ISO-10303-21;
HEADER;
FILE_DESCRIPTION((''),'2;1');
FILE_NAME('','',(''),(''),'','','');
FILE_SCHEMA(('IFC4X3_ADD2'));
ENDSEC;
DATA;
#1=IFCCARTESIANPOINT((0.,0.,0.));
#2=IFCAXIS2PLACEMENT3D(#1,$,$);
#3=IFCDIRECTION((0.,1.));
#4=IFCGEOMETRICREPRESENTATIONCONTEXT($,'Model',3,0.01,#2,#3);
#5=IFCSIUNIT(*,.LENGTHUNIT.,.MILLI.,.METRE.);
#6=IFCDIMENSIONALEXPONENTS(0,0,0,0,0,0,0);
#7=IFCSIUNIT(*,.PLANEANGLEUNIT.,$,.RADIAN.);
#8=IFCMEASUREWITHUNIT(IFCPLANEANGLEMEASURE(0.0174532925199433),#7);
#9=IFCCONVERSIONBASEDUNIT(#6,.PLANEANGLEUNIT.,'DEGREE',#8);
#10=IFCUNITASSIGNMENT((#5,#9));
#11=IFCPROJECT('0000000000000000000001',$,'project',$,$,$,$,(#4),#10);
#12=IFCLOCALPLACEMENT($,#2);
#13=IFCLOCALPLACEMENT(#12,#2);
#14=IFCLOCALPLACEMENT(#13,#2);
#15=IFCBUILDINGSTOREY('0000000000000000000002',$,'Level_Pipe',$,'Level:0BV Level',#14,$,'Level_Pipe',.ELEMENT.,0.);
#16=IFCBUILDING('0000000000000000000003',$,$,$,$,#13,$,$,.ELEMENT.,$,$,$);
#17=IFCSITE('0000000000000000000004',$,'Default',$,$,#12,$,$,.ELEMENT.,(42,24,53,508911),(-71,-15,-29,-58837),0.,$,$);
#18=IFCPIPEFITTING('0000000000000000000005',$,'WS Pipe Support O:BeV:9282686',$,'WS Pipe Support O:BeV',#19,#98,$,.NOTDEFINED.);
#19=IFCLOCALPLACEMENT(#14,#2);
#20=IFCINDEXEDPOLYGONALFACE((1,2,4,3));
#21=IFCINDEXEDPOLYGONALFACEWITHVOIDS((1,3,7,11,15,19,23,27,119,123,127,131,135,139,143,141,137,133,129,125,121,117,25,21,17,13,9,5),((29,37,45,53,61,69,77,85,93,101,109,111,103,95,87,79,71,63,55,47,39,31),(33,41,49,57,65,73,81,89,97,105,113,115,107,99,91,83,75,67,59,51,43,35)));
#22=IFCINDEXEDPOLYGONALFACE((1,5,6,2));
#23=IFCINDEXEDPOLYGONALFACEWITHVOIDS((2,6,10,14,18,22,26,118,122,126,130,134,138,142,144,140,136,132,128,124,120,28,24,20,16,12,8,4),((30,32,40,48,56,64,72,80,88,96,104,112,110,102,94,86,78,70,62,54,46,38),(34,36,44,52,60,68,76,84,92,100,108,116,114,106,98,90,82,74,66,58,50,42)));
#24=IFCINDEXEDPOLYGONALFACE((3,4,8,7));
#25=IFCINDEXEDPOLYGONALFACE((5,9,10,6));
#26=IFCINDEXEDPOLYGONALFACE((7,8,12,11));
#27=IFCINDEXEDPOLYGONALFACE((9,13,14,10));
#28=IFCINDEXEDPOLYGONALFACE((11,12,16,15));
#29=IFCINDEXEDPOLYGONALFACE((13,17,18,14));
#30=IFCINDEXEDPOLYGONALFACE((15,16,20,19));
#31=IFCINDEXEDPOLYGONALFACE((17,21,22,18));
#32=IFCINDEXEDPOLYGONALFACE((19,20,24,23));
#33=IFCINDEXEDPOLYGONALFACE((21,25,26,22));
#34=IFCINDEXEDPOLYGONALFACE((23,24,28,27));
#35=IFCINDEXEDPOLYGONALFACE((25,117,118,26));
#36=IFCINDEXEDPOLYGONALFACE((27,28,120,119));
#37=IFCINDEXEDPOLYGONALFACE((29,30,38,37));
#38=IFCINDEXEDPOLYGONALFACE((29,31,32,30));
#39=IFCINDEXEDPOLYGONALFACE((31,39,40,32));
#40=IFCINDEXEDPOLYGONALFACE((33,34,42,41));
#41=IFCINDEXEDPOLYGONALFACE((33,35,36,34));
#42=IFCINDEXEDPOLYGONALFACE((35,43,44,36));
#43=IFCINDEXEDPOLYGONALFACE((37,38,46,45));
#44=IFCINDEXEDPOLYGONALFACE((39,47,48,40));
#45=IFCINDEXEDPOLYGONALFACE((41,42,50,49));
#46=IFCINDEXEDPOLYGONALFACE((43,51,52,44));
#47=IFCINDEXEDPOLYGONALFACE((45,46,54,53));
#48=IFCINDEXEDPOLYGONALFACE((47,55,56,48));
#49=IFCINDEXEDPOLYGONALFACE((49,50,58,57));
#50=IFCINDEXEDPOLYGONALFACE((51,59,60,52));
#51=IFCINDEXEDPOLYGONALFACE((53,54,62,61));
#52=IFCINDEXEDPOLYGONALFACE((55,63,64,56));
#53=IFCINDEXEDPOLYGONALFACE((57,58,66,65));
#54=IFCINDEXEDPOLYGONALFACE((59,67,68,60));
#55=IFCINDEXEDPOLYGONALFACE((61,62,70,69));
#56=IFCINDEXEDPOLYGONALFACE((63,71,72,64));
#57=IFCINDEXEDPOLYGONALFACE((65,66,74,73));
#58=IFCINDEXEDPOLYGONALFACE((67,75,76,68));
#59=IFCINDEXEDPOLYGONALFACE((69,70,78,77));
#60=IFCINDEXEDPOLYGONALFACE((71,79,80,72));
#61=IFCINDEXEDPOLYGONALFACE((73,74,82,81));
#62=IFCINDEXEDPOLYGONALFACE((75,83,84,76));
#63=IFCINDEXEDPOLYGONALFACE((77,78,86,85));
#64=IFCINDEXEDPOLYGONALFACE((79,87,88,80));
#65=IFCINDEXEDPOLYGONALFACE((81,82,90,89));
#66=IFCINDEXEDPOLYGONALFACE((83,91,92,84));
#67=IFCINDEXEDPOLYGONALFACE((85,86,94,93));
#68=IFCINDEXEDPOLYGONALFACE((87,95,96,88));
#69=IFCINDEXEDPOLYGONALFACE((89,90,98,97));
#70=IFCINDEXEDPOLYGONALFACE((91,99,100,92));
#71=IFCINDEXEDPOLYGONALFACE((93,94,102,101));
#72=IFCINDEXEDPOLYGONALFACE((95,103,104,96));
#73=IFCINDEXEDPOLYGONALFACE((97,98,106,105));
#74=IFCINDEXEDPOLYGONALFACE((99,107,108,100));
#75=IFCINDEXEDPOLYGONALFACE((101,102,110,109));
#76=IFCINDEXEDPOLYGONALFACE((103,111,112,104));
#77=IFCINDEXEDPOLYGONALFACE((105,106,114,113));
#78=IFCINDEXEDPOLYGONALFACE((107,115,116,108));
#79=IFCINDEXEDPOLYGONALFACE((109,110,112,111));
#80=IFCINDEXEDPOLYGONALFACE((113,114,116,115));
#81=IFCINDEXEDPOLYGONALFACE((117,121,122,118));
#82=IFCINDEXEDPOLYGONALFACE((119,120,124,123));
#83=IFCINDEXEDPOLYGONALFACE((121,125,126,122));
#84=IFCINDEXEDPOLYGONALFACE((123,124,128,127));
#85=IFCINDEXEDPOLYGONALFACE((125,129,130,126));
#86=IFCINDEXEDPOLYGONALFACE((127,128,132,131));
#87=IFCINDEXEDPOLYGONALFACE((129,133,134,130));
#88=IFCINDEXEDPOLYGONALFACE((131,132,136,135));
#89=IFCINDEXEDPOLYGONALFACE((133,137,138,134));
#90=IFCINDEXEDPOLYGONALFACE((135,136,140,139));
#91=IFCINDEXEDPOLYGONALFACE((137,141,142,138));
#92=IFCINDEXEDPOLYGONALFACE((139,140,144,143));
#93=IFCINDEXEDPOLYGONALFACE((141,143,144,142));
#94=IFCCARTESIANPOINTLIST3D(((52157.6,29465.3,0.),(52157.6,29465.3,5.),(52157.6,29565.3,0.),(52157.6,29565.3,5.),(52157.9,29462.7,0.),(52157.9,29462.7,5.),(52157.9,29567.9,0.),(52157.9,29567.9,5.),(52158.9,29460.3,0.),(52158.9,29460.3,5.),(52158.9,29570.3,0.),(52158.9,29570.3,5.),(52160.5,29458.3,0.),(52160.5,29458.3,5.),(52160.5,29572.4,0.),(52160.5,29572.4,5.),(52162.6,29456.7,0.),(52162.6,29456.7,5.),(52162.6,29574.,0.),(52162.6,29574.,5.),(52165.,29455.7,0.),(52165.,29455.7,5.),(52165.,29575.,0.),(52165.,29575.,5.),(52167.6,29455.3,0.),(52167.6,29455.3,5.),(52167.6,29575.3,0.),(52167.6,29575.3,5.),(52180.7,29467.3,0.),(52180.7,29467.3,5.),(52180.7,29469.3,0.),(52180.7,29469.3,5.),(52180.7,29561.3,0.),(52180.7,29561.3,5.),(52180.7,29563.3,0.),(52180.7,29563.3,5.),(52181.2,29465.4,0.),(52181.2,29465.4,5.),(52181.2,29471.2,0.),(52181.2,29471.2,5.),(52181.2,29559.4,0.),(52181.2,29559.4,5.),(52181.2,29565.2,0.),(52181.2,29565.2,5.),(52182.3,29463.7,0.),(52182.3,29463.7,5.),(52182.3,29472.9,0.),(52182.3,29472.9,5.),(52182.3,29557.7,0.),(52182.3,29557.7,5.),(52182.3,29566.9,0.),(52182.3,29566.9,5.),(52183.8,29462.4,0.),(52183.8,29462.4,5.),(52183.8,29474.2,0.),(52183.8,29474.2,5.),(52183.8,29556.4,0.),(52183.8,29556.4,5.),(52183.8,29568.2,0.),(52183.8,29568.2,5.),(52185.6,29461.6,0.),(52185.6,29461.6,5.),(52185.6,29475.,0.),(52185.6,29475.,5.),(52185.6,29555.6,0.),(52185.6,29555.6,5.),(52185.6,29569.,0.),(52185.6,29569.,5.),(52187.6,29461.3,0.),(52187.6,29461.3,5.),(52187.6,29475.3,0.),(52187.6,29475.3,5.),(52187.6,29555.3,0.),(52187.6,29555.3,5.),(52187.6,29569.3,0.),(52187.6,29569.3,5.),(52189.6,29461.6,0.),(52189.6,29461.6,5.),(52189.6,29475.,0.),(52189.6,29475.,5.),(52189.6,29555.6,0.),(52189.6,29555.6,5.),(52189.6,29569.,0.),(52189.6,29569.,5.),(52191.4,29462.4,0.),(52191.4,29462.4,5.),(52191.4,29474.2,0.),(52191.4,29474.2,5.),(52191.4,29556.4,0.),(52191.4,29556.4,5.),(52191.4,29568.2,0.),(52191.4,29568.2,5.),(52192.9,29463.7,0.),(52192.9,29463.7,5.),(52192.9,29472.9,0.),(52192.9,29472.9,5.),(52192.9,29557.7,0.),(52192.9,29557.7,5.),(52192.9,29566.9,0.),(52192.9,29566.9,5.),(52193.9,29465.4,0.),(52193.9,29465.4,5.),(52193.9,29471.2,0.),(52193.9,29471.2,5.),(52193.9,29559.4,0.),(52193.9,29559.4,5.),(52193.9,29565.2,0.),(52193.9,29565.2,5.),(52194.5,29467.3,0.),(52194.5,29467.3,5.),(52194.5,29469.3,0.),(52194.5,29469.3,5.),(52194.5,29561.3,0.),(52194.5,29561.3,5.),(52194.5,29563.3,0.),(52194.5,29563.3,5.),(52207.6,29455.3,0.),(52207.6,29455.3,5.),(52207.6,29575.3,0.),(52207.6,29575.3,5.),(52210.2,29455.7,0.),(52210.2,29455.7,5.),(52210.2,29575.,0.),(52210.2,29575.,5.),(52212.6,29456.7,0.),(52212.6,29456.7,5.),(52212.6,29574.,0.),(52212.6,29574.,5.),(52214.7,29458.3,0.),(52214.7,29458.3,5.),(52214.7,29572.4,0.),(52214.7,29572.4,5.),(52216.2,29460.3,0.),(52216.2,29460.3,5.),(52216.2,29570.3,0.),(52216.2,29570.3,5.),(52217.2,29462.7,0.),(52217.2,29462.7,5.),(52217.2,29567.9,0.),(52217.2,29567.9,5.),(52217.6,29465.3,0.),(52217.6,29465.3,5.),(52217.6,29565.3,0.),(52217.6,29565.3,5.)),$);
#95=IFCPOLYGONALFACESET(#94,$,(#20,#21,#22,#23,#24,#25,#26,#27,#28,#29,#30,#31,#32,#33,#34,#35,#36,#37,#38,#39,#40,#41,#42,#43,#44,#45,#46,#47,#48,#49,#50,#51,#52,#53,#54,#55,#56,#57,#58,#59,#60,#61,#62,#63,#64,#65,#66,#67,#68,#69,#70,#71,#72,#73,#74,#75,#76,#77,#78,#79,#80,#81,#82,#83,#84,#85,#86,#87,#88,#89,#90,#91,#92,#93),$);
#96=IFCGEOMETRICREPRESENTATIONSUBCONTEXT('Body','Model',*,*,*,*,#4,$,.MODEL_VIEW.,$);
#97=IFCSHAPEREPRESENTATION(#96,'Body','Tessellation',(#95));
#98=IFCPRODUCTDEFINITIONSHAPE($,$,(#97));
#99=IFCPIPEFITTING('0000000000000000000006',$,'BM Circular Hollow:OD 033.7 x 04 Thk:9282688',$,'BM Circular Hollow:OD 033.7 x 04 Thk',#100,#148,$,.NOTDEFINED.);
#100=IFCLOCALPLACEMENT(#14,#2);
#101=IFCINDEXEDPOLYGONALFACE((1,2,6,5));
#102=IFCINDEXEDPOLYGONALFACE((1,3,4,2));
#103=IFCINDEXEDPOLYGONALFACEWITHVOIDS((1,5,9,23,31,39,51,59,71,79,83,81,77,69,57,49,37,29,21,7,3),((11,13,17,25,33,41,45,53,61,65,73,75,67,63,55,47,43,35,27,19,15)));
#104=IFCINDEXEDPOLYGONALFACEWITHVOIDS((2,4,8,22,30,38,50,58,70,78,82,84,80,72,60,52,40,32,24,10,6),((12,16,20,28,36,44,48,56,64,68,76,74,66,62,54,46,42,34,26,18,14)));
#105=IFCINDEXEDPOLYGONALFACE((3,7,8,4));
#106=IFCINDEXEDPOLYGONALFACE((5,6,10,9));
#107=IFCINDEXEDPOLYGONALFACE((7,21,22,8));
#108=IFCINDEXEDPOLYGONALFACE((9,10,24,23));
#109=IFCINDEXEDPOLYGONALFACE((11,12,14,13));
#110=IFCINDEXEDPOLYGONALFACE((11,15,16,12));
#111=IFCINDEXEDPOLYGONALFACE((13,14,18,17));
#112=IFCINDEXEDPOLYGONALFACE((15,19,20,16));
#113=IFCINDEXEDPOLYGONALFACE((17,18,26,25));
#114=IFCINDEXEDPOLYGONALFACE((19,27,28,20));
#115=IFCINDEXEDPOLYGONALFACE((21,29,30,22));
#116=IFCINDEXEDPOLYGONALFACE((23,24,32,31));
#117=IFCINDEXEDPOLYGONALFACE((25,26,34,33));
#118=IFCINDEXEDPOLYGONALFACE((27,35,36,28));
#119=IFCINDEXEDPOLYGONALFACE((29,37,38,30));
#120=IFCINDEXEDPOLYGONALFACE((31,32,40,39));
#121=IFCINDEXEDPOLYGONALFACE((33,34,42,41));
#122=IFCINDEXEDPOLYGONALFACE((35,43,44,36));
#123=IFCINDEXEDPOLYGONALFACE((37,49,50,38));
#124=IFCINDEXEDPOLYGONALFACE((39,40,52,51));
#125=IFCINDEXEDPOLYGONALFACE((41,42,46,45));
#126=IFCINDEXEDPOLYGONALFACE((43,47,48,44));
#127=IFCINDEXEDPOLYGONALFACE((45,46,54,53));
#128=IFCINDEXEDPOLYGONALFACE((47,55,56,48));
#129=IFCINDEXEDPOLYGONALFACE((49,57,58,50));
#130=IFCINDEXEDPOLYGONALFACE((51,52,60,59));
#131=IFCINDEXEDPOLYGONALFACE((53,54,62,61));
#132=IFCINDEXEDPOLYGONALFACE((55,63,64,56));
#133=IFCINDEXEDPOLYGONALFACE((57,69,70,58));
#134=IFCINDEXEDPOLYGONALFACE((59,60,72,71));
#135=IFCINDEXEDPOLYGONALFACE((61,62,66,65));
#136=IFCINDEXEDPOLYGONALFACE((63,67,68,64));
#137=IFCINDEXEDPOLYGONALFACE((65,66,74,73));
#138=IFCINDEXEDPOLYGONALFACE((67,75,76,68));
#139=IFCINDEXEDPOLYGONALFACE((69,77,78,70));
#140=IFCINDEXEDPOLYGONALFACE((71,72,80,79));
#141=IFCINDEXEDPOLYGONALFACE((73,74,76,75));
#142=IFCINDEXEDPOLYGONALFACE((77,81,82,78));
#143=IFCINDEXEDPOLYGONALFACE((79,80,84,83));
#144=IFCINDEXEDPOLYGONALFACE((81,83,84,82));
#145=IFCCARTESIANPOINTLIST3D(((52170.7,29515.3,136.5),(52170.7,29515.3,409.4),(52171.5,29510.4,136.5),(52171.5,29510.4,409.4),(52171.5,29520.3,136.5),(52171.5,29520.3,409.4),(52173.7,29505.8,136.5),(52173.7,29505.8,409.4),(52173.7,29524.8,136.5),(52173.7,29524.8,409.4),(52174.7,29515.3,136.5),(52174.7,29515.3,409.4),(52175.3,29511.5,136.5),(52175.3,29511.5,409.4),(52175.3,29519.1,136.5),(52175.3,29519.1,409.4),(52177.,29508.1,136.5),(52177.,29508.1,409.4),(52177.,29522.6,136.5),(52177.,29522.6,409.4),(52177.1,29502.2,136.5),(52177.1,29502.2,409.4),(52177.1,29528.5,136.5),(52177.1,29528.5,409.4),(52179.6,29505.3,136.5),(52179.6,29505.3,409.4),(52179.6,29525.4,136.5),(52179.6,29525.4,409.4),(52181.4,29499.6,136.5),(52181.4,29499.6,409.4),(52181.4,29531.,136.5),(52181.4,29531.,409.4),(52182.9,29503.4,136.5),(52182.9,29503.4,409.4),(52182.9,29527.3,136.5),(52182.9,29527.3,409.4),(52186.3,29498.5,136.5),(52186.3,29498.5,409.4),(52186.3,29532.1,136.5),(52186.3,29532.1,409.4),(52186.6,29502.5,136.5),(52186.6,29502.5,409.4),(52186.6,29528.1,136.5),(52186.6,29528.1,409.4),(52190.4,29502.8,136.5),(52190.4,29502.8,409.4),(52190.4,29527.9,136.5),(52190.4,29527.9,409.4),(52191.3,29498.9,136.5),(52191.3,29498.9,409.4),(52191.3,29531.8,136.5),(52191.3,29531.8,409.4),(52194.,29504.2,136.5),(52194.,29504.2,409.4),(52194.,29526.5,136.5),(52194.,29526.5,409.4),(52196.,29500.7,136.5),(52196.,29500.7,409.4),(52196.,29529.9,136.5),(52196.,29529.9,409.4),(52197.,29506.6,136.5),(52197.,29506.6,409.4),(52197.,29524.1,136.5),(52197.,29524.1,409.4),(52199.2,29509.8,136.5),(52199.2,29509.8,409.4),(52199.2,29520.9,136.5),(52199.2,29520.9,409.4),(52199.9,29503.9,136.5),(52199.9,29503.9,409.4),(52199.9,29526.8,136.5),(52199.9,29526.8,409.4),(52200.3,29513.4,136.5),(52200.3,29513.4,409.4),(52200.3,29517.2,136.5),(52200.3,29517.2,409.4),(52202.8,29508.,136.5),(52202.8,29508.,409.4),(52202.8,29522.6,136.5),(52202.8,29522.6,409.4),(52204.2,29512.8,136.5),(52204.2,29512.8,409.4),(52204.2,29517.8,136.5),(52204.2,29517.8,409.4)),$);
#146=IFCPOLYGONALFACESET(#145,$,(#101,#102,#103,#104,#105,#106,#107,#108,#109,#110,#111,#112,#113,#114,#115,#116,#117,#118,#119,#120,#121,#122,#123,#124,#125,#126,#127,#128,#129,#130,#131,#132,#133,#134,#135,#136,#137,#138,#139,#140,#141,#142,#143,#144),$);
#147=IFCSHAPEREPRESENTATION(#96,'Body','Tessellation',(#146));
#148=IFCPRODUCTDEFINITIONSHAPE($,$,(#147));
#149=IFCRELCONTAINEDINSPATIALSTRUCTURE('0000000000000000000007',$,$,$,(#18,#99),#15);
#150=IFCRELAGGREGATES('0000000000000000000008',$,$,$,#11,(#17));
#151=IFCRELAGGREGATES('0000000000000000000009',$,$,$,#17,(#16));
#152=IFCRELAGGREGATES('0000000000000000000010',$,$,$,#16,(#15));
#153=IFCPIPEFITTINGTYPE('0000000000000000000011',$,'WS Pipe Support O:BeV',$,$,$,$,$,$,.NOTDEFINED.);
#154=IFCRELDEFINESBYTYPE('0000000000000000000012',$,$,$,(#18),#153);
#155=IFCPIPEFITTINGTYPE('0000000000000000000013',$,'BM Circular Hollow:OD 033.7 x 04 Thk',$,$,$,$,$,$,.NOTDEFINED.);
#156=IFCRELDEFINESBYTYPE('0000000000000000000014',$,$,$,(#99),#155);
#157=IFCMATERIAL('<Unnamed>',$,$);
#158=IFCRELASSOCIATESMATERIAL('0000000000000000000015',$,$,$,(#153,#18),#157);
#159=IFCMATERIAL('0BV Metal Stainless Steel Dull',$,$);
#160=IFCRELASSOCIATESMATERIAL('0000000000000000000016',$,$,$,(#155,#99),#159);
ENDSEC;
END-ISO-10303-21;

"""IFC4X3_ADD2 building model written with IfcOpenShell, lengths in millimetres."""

from ifc_helpers import new_model, entity, si_unit, converted_unit, direction, frame, frame_2d, origin, place, context, subcontext, project, spatial, polyline, circle_curve, parameter, trimmed, segment, composite_curve, hollow_circle, outline, extrude, source, transform, mapped, material, type_object, type_shapes, element, save


model = new_model("IFC4X3_ADD2")

# Units and contexts
model_context = context("Model", 3, precision=0.01, world=origin(), true_north=direction((0.0, 1.0)))
body_context = subcontext(model_context, "Body", "Model", "MODEL_VIEW")
ifc_project = project(units=[si_unit("LENGTHUNIT", "METRE", prefix="MILLI"), converted_unit("PLANEANGLEUNIT", "DEGREE", entity("IfcPlaneAngleMeasure", 0.0174532925199433), si_unit("PLANEANGLEUNIT", "RADIAN"), dimensions=[0, 0, 0, 0, 0, 0, 0])], contexts=[model_context])

# Site, building, storey
site_placement = place(None, origin())
site = spatial("IfcSite", under=ifc_project, at=site_placement, Name="Default", CompositionType="ELEMENT", RefLatitude=(42, 24, 53, 508911), RefLongitude=(-71, -15, -29, -58837), RefElevation=0.0)
building_placement = place(site_placement, origin())
building = spatial("IfcBuilding", under=site, at=building_placement, CompositionType="ELEMENT")
storey_placement = place(building_placement, origin())
storey = spatial("IfcBuildingStorey", under=building, at=storey_placement, Name="Level_Pipe", ObjectType="Level:0BV Level", LongName="Level_Pipe", CompositionType="ELEMENT", Elevation=0.0)

# Shared definitions
ifc_material_1 = material(Name="0BV Metal Stainless Steel Dull")
ifc_material_2 = material(Name="<Unnamed>")

# Pipe fittings
pipe_fitting_type_1 = type_object("IfcPipeFittingType", Name="WS Pipe Support O:BeV", PredefinedType="NOTDEFINED", material=ifc_material_2)
shared_shape_1 = source(origin(), body_context, "Body", "SweptSolid", [
    extrude(outline(composite_curve([segment(trimmed(circle_curve(frame_2d((50.0, -20.0), x_axis=(1.0, 0.0)), 10.0), [parameter(270.0)], [parameter(0.0)], True, "PARAMETER"), True, "CONTINUOUS"), segment(polyline([(60.0, -20.0), (60.0, 20.0)]), True, "CONTINUOUS"), segment(trimmed(circle_curve(frame_2d((50.0, 20.0), x_axis=(1.0, 0.0)), 10.0), [parameter(0.0)], [parameter(90.0)], True, "PARAMETER"), True, "CONTINUOUS"), segment(polyline([(50.0, 30.0), (-50.0, 30.0)]), True, "CONTINUOUS"), segment(trimmed(circle_curve(frame_2d((-50.0, 20.0), x_axis=(1.0, 0.0)), 10.0), [parameter(90.0)], [parameter(180.0)], True, "PARAMETER"), True, "CONTINUOUS"), segment(polyline([(-60.0, 20.0), (-60.0, -20.0)]), True, "CONTINUOUS"), segment(trimmed(circle_curve(frame_2d((-50.0, -20.0), x_axis=(1.0, 0.0)), 10.0), [parameter(180.0)], [parameter(270.0)], True, "PARAMETER"), True, "CONTINUOUS"), segment(polyline([(-50.0, -30.0), (50.0, -30.0)]), True, "CONTINUOUS")], self_intersect=False), holes=[composite_curve([segment(trimmed(circle_curve(frame_2d((-47.0, 0.0), x_axis=(1.0, 0.0)), 7.0), [parameter(0.0)], [parameter(180.0)], True, "PARAMETER"), False, "CONTINUOUS"), segment(trimmed(circle_curve(frame_2d((-47.0, 0.0), x_axis=(1.0, 0.0)), 7.0), [parameter(180.0)], [parameter(360.0)], True, "PARAMETER"), False, "CONTINUOUS")], self_intersect=False), composite_curve([segment(trimmed(circle_curve(frame_2d((47.0, 0.0), x_axis=(1.0, 0.0)), 7.0), [parameter(0.0)], [parameter(180.0)], True, "PARAMETER"), False, "CONTINUOUS"), segment(trimmed(circle_curve(frame_2d((47.0, 0.0), x_axis=(1.0, 0.0)), 7.0), [parameter(180.0)], [parameter(360.0)], True, "PARAMETER"), False, "CONTINUOUS")], self_intersect=False)]), origin(), (0.0, 0.0, 1.0), 5.0),
])
type_shapes(pipe_fitting_type_1, [shared_shape_1])
pipe_fitting_1_placement = place(storey_placement, frame((52187.6, 29515.3, 0.0), z_axis=(0.0, 0.0, 1.0), x_axis=(0.0, -1.0, 0.0)))
element("IfcPipeFitting", 1, at=pipe_fitting_1_placement, inside=storey, type_object=pipe_fitting_type_1, material=ifc_material_2, Name="WS Pipe Support O:BeV:9282686", ObjectType="WS Pipe Support O:BeV", PredefinedType="NOTDEFINED", context=body_context, shape_type="MappedRepresentation", body=[
    mapped(shared_shape_1, transform((0.0, 0.0, 0.0), scale=1.0)),
])
pipe_fitting_type_2 = type_object("IfcPipeFittingType", Name="BM Circular Hollow:OD 033.7 x 04 Thk", PredefinedType="NOTDEFINED", material=ifc_material_1)
shared_shape_2 = source(origin(), body_context, "Body", "SweptSolid", [
    extrude(hollow_circle(Radius=16.9, WallThickness=4.0, at=frame_2d((0.0, 0.0), x_axis=(1.0, 0.0))), frame((-136.5, 0.0, 0.0), z_axis=(1.0, 0.0, 0.0), x_axis=(0.0, -1.0, 0.0)), (0.0, 0.0, 1.0), 272.9),
])
type_shapes(pipe_fitting_type_2, [shared_shape_2])
pipe_fitting_2_placement = place(storey_placement, frame((52187.6, 29515.3, 272.9), z_axis=(0.0, 1.0, 0.0), x_axis=(0.0, 0.0, 1.0)))
element("IfcPipeFitting", 2, at=pipe_fitting_2_placement, inside=storey, type_object=pipe_fitting_type_2, material=ifc_material_1, Name="BM Circular Hollow:OD 033.7 x 04 Thk:9282688", ObjectType="BM Circular Hollow:OD 033.7 x 04 Thk", PredefinedType="NOTDEFINED", context=body_context, shape_type="MappedRepresentation", body=[
    mapped(shared_shape_2, transform((0.0, 0.0, 0.0), scale=1.0)),
])

save(model, "model.ifc")
